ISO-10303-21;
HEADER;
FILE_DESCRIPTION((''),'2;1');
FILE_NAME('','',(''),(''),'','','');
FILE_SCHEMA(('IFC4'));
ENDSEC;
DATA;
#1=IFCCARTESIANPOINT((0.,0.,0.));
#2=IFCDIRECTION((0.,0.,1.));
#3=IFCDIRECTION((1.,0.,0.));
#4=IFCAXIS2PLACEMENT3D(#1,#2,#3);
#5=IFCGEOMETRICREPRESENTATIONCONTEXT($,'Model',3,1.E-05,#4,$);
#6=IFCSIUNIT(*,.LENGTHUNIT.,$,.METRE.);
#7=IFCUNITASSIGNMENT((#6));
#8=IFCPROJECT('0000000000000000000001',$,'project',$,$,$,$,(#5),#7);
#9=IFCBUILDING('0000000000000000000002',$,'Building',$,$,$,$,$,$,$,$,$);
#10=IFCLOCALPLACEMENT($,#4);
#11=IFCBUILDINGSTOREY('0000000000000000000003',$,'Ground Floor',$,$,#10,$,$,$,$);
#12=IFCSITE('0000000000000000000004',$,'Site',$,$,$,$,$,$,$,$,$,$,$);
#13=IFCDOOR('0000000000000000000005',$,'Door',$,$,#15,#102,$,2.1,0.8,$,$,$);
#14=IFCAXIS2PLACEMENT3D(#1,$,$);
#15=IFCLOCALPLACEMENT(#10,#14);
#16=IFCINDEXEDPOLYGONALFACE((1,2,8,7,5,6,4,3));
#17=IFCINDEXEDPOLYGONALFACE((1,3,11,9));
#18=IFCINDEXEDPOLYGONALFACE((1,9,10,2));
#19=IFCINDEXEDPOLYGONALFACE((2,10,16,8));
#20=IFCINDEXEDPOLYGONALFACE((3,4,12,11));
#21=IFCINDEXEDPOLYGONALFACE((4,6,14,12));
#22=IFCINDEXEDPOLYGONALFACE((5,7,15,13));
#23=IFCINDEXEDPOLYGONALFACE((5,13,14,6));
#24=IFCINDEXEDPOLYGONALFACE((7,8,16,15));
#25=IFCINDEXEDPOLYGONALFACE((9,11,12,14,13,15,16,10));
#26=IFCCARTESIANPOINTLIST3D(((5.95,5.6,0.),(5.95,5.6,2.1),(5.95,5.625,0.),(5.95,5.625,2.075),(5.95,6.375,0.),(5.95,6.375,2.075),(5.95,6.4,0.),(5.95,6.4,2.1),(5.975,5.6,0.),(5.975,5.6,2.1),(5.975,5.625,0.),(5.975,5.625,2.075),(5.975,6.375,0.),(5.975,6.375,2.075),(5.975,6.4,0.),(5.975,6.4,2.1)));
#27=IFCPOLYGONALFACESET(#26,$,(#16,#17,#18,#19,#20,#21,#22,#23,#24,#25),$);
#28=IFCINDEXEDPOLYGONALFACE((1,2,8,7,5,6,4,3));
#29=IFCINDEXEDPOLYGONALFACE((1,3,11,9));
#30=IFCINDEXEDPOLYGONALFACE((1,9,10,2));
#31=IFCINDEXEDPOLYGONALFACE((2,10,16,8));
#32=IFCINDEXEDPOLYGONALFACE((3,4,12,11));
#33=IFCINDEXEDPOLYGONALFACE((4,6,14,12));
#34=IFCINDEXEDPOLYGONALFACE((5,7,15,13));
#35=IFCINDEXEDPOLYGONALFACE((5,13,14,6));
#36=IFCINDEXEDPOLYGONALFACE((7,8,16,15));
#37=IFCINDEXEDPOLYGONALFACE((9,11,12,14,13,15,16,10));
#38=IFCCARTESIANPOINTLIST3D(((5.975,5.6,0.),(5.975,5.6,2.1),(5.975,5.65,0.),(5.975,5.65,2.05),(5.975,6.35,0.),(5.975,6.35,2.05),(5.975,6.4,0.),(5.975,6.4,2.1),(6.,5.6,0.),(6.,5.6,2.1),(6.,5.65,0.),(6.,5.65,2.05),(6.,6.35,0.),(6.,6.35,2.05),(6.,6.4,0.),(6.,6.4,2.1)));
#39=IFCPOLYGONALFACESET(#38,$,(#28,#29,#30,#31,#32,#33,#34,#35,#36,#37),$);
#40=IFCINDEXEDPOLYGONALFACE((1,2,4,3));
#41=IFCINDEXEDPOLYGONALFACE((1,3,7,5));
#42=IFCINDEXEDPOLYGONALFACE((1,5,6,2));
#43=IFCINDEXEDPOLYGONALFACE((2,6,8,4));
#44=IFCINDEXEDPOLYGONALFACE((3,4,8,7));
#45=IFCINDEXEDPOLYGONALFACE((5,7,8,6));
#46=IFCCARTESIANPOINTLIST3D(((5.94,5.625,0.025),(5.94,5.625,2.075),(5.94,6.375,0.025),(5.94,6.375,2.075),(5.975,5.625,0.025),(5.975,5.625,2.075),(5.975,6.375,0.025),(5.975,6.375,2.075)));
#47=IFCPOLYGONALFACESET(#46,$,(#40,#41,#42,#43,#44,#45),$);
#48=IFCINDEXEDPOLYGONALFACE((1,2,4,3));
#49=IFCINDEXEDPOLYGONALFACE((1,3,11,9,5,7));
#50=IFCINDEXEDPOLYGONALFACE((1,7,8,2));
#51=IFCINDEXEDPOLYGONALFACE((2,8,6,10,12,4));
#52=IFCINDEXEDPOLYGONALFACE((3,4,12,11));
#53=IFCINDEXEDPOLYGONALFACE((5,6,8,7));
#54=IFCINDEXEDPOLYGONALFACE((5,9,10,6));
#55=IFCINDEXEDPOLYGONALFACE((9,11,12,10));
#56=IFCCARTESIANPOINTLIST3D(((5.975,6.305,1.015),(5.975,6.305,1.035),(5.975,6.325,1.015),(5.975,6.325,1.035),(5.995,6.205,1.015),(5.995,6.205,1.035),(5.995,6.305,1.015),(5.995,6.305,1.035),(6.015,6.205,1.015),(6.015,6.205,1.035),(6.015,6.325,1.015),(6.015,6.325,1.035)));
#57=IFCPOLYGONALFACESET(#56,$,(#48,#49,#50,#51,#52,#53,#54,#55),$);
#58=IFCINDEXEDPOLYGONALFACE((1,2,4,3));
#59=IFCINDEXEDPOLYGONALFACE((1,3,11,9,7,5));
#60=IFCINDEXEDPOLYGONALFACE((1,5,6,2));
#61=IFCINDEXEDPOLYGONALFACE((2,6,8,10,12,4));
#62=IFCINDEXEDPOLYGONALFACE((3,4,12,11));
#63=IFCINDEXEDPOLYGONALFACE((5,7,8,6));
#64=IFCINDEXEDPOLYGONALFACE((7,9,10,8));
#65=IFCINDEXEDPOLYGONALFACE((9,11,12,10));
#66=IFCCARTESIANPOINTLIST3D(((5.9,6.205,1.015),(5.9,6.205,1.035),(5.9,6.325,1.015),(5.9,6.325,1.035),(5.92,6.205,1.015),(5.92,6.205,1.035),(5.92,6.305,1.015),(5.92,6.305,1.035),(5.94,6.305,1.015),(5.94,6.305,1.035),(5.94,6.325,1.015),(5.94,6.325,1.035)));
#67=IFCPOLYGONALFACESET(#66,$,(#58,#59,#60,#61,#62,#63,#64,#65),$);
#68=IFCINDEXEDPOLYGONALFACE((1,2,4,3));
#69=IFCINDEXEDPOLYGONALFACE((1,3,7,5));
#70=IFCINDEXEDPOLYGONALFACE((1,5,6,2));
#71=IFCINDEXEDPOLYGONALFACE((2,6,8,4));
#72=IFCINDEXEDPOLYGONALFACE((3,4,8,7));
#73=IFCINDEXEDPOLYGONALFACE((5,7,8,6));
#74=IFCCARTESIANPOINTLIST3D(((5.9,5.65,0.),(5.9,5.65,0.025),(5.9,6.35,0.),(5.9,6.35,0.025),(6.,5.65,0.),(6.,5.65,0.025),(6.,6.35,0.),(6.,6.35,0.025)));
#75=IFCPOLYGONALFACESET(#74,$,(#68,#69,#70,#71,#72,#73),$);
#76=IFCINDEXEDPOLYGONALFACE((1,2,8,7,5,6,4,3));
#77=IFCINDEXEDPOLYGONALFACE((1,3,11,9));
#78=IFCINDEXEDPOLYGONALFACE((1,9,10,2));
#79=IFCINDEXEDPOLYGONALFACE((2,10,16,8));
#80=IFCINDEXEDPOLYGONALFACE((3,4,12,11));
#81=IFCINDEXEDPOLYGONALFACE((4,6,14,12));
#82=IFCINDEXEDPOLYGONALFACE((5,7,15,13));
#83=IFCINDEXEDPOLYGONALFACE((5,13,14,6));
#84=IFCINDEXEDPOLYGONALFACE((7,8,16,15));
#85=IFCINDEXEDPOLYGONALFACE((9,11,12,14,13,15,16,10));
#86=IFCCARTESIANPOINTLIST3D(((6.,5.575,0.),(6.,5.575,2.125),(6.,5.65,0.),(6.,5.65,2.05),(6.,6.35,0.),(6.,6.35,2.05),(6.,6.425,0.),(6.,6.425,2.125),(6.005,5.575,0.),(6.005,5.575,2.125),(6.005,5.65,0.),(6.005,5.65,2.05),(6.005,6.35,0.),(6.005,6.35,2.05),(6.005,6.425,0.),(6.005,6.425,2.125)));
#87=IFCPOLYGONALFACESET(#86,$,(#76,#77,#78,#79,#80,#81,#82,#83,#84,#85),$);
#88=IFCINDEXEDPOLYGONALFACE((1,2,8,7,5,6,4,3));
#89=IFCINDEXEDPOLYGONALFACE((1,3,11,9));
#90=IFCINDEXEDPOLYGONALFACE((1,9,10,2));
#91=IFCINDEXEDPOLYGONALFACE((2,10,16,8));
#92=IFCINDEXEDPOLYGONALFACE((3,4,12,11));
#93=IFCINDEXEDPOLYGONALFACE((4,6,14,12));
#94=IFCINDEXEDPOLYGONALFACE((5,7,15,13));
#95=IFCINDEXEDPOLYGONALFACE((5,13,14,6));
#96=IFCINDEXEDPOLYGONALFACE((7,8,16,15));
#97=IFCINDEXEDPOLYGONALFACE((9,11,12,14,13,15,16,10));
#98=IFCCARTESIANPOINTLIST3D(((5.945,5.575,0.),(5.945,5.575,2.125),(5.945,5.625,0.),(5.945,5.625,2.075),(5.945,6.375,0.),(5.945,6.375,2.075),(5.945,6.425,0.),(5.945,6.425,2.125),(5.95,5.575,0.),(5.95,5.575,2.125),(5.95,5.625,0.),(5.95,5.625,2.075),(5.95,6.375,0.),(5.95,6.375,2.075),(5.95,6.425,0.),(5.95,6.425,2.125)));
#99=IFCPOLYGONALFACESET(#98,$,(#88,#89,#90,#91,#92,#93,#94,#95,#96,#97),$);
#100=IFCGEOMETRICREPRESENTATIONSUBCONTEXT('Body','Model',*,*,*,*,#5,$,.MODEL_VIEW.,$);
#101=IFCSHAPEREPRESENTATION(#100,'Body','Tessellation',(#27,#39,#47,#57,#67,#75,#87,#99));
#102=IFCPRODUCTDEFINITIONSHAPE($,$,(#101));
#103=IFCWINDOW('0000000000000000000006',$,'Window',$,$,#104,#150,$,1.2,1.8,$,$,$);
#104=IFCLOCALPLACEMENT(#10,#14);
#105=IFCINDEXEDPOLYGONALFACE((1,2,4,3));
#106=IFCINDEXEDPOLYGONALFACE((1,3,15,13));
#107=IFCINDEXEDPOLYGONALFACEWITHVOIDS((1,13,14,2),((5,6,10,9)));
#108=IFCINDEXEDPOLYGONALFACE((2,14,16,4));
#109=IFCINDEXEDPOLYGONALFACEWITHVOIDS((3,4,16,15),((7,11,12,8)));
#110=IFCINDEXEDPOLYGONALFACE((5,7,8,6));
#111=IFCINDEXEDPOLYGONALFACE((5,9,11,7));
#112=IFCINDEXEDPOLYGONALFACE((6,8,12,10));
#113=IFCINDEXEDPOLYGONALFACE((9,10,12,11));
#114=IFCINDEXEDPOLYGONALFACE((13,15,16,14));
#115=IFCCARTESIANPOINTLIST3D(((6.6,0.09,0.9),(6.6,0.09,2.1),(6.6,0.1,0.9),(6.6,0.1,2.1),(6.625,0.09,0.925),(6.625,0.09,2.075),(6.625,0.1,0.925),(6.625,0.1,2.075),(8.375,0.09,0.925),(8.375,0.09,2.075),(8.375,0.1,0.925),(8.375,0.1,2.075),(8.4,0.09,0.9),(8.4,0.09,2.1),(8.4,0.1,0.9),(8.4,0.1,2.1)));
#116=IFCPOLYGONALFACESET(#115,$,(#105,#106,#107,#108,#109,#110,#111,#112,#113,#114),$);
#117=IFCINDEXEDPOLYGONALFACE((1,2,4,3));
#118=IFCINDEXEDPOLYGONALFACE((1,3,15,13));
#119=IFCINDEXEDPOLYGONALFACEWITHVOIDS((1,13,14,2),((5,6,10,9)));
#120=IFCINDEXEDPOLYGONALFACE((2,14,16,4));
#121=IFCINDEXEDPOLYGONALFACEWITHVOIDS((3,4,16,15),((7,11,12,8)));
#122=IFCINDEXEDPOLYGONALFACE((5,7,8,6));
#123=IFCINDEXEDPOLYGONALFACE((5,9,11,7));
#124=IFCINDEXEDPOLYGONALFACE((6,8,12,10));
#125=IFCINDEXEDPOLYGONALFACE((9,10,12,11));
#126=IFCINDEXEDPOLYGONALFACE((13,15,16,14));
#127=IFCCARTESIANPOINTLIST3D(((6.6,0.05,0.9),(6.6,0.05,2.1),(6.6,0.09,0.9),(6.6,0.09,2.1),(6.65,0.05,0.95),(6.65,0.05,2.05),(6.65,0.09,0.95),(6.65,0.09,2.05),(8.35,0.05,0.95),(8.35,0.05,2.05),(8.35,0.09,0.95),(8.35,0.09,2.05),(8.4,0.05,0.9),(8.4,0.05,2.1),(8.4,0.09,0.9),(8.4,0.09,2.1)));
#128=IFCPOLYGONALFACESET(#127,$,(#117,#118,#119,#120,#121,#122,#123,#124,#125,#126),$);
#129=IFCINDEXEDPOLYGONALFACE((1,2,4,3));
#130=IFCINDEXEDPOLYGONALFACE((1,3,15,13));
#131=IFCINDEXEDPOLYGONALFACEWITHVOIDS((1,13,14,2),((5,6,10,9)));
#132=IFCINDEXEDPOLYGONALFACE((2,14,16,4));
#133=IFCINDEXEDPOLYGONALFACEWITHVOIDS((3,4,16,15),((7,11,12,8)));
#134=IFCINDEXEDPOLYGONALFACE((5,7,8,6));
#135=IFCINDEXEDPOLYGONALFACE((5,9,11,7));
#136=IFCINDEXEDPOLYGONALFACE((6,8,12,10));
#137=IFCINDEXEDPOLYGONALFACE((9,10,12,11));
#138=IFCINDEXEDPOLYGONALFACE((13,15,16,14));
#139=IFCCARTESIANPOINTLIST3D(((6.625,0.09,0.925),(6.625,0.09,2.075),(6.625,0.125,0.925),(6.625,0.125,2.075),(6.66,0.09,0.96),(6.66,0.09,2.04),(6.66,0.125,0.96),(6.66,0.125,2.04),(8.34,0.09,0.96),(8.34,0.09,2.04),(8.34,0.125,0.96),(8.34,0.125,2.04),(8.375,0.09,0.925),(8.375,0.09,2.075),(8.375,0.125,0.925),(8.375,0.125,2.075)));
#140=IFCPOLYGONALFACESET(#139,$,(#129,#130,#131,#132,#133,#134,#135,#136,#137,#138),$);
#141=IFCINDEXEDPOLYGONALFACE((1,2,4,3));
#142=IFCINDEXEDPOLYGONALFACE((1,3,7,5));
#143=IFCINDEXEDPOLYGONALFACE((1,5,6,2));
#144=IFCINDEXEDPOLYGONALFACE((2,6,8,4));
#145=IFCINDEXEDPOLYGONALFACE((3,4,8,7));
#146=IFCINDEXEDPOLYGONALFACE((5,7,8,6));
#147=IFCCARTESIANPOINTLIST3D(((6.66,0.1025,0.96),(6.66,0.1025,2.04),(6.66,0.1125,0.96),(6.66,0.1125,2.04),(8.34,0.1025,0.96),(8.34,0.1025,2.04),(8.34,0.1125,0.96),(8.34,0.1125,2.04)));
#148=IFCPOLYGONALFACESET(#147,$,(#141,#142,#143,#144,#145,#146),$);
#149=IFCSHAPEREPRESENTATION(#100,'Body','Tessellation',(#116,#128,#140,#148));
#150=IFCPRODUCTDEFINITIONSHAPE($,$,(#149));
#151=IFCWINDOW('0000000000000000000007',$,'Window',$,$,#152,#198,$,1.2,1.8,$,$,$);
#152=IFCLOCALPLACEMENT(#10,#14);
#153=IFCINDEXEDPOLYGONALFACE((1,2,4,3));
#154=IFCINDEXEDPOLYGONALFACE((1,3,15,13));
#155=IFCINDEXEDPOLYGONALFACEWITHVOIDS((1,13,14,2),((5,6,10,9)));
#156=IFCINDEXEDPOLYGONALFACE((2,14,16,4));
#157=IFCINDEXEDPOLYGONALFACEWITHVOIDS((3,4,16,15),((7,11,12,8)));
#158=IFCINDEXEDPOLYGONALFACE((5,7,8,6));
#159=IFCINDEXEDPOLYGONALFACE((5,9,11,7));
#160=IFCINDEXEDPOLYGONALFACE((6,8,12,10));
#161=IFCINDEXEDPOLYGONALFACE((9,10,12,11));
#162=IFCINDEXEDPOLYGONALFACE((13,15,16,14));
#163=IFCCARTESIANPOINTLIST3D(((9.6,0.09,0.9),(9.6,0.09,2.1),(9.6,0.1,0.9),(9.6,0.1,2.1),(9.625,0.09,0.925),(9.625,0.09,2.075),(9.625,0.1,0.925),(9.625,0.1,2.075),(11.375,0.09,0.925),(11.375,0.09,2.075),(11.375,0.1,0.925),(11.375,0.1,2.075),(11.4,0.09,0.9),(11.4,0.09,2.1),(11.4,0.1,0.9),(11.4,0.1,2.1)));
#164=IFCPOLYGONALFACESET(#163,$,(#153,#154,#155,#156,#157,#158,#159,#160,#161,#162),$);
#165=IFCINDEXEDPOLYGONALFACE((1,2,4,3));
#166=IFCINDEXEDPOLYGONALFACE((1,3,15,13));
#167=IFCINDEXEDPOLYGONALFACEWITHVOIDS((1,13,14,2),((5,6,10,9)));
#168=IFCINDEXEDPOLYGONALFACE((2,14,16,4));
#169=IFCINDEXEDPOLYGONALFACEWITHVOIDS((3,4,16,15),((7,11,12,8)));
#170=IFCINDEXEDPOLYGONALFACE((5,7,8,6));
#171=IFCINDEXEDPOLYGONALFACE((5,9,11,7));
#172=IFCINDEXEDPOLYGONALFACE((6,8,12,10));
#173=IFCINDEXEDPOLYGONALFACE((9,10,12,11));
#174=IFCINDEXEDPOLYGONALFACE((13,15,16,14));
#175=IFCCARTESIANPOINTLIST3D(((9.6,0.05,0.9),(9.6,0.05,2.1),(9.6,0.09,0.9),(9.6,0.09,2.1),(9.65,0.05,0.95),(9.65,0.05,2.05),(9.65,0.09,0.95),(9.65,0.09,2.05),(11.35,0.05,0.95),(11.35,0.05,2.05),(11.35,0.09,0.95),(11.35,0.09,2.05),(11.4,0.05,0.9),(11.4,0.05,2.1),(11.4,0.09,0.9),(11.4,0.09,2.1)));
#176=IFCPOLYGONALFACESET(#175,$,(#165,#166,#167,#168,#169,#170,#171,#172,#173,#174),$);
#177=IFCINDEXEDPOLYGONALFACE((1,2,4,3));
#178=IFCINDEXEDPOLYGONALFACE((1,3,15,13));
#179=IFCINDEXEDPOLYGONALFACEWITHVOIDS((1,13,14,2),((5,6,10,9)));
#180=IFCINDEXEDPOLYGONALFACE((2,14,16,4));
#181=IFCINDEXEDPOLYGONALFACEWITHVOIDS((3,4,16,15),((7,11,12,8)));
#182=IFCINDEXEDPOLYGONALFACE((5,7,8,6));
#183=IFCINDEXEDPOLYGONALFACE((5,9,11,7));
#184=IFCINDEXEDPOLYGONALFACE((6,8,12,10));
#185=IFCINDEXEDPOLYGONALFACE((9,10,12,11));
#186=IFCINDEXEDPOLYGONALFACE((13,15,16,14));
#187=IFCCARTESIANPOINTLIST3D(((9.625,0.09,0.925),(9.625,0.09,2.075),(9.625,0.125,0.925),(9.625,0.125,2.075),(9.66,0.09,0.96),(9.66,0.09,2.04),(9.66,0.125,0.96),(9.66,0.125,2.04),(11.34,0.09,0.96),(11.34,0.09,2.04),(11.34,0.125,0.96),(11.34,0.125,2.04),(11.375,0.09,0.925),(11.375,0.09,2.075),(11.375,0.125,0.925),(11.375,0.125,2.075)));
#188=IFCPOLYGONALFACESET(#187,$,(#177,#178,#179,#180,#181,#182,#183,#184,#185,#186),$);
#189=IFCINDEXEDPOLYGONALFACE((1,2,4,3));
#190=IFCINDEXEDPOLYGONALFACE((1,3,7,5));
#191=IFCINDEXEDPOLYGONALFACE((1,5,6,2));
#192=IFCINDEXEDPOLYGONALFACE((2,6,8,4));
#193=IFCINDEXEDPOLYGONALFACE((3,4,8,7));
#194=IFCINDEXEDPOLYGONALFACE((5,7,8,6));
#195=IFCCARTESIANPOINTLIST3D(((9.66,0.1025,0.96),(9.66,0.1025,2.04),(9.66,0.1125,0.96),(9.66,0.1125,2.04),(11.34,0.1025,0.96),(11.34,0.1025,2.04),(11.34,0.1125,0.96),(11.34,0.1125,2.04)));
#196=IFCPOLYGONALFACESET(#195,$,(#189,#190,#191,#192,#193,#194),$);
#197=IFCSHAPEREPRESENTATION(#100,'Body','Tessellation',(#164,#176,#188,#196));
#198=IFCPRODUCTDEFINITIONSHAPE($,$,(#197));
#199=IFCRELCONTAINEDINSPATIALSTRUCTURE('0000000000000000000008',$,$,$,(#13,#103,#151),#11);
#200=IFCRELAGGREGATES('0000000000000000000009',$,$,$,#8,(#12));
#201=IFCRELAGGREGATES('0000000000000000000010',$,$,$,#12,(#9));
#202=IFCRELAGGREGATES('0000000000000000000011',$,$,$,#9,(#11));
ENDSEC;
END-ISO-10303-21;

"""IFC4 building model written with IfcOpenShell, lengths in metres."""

from ifc_helpers import new_model, si_unit, frame, origin_with_axes, place, context, subcontext, project, spatial, line, indexed_curve, outline, extrude, element, save


model = new_model("IFC4")

# Units and contexts
model_context = context("Model", 3, precision=1e-05, world=origin_with_axes())
body_context = subcontext(model_context, "Body", "Model", "MODEL_VIEW")
ifc_project = project(units=[si_unit("LENGTHUNIT", "METRE")], contexts=[model_context])

# Site, building, storey
site = spatial("IfcSite", under=ifc_project, Name="Site")
building = spatial("IfcBuilding", under=site, Name="Building")
storey_placement = place(None, origin_with_axes())
storey = spatial("IfcBuildingStorey", under=building, at=storey_placement, Name="Ground Floor")

# Door
door_1_placement = place(storey_placement, frame((6.0, 5.6, 0.0), z_axis=(0.0, 0.0, 1.0), x_axis=(0.0, 1.0, 0.0)))
element("IfcDoor", 1, at=door_1_placement, inside=storey, Name="Door", OverallHeight=2.1, OverallWidth=0.8, context=body_context, shape_type="SweptSolid", body=[
    extrude(outline(indexed_curve([(0.0, 0.0), (0.0, 2.1), (0.8, 2.1), (0.8, 0.0), (0.775, 0.0), (0.775, 2.075), (0.025, 2.075), (0.025, 0.0)], segments=[line(1, 2, 3, 4, 5, 6, 7, 8, 1)])), frame((0.0, 0.025, 0.0), z_axis=(0.0, -1.0, 0.0), x_axis=(1.0, 0.0, 0.0)), (0.0, 0.0, -1.0), 0.025),
    extrude(outline(indexed_curve([(0.0, 0.0), (0.0, 2.1), (0.8, 2.1), (0.8, 0.0), (0.75, 0.0), (0.75, 2.05), (0.05, 2.05), (0.05, 0.0)], segments=[line(1, 2, 3, 4, 5, 6, 7, 8, 1)])), frame((0.0, 0.0, 0.0), z_axis=(0.0, -1.0, 0.0), x_axis=(1.0, 0.0, 0.0)), (0.0, 0.0, -1.0), 0.025),
    extrude(outline(indexed_curve([(0.0, 0.0), (0.75, 0.0), (0.75, 0.035), (0.0, 0.035)], segments=[line(1, 2, 3, 4, 1)])), frame((0.025, 0.025, 0.025), z_axis=(0.0, 0.0, 1.0), x_axis=(1.0, 0.0, 0.0)), (0.0, 0.0, 1.0), 2.05),
    extrude(outline(indexed_curve([(0.0, 0.0), (0.0, -0.04), (-0.12, -0.04), (-0.12, -0.02), (-0.02, -0.02), (-0.02, 0.0)], segments=[line(1, 2, 3, 4, 5, 6, 1)])), frame((0.725, 0.025, 1.015), z_axis=(0.0, 0.0, 1.0), x_axis=(1.0, 0.0, 0.0)), (0.0, 0.0, 1.0), 0.02),
    extrude(outline(indexed_curve([(0.0, 0.0), (0.0, 0.04), (-0.12, 0.04), (-0.12, 0.02), (-0.02, 0.02), (-0.02, 0.0)], segments=[line(1, 2, 3, 4, 5, 6, 1)])), frame((0.725, 0.06, 1.015), z_axis=(0.0, 0.0, 1.0), x_axis=(1.0, 0.0, 0.0)), (0.0, 0.0, 1.0), 0.02),
    extrude(outline(indexed_curve([(0.0, 0.0), (0.7, 0.0), (0.7, 0.1), (0.0, 0.1)], segments=[line(1, 2, 3, 4, 1)])), frame((0.05, 0.0, 0.0), z_axis=(0.0, 0.0, 1.0), x_axis=(1.0, 0.0, 0.0)), (0.0, 0.0, 1.0), 0.025),
    extrude(outline(indexed_curve([(0.0, 0.0), (0.0, 2.125), (0.85, 2.125), (0.85, 0.0), (0.775, 0.0), (0.775, 2.05), (0.075, 2.05), (0.075, 0.0)], segments=[line(1, 2, 3, 4, 5, 6, 7, 8, 1)])), frame((-0.025, -0.005, 0.0), z_axis=(0.0, -1.0, 0.0), x_axis=(1.0, 0.0, 0.0)), (0.0, 0.0, -1.0), 0.005),
    extrude(outline(indexed_curve([(0.0, 0.0), (0.0, 2.125), (0.85, 2.125), (0.85, 0.0), (0.8, 0.0), (0.8, 2.075), (0.05, 2.075), (0.05, 0.0)], segments=[line(1, 2, 3, 4, 5, 6, 7, 8, 1)])), frame((-0.025, 0.05, 0.0), z_axis=(0.0, -1.0, 0.0), x_axis=(1.0, 0.0, 0.0)), (0.0, 0.0, -1.0), 0.005),
])

# Windows
for number, where, z_axis, x_axis, name in (
    (2, (6.6, 0.0, 0.9), (0.0, 0.0, 1.0), (1.0, 0.0, 0.0), "Window"),
    (3, (9.6, 0.0, 0.9), (0.0, 0.0, 1.0), (1.0, 0.0, 0.0), "Window"),
):
    element("IfcWindow", number, at=place(storey_placement, frame(where, z_axis=z_axis, x_axis=x_axis)), inside=storey, Name=name, OverallHeight=1.2, OverallWidth=1.8, context=body_context, shape_type="SweptSolid", body=[
        extrude(outline(indexed_curve([(0.0, 0.0), (1.8, 0.0), (1.8, 1.2), (0.0, 1.2)], segments=[line(1, 2, 3, 4, 1)]), holes=[indexed_curve([(0.025, 0.025), (1.775, 0.025), (1.775, 1.175), (0.025, 1.175)], segments=[line(1, 2, 3, 4, 1)])]), frame((0.0, 0.09, 0.0), z_axis=(0.0, -1.0, 0.0), x_axis=(1.0, 0.0, 0.0)), (0.0, 0.0, -1.0), 0.01),
        extrude(outline(indexed_curve([(0.0, 0.0), (1.8, 0.0), (1.8, 1.2), (0.0, 1.2)], segments=[line(1, 2, 3, 4, 1)]), holes=[indexed_curve([(0.05, 0.05), (1.75, 0.05), (1.75, 1.15), (0.05, 1.15)], segments=[line(1, 2, 3, 4, 1)])]), frame((0.0, 0.05, 0.0), z_axis=(0.0, -1.0, 0.0), x_axis=(1.0, 0.0, 0.0)), (0.0, 0.0, -1.0), 0.04),
        extrude(outline(indexed_curve([(0.0, 0.0), (1.75, 0.0), (1.75, 1.15), (0.0, 1.15)], segments=[line(1, 2, 3, 4, 1)]), holes=[indexed_curve([(0.035, 0.035), (1.715, 0.035), (1.715, 1.115), (0.035, 1.115)], segments=[line(1, 2, 3, 4, 1)])]), frame((0.025, 0.09, 0.025), z_axis=(0.0, -1.0, 0.0), x_axis=(1.0, 0.0, 0.0)), (0.0, 0.0, -1.0), 0.035),
        extrude(outline(indexed_curve([(0.035, 0.035), (1.715, 0.035), (1.715, 1.115), (0.035, 1.115)], segments=[line(1, 2, 3, 4, 1)])), frame((0.025, 0.1025, 0.025), z_axis=(0.0, -1.0, 0.0), x_axis=(1.0, 0.0, 0.0)), (0.0, 0.0, -1.0), 0.01),
    ])

save(model, "model.ifc")
